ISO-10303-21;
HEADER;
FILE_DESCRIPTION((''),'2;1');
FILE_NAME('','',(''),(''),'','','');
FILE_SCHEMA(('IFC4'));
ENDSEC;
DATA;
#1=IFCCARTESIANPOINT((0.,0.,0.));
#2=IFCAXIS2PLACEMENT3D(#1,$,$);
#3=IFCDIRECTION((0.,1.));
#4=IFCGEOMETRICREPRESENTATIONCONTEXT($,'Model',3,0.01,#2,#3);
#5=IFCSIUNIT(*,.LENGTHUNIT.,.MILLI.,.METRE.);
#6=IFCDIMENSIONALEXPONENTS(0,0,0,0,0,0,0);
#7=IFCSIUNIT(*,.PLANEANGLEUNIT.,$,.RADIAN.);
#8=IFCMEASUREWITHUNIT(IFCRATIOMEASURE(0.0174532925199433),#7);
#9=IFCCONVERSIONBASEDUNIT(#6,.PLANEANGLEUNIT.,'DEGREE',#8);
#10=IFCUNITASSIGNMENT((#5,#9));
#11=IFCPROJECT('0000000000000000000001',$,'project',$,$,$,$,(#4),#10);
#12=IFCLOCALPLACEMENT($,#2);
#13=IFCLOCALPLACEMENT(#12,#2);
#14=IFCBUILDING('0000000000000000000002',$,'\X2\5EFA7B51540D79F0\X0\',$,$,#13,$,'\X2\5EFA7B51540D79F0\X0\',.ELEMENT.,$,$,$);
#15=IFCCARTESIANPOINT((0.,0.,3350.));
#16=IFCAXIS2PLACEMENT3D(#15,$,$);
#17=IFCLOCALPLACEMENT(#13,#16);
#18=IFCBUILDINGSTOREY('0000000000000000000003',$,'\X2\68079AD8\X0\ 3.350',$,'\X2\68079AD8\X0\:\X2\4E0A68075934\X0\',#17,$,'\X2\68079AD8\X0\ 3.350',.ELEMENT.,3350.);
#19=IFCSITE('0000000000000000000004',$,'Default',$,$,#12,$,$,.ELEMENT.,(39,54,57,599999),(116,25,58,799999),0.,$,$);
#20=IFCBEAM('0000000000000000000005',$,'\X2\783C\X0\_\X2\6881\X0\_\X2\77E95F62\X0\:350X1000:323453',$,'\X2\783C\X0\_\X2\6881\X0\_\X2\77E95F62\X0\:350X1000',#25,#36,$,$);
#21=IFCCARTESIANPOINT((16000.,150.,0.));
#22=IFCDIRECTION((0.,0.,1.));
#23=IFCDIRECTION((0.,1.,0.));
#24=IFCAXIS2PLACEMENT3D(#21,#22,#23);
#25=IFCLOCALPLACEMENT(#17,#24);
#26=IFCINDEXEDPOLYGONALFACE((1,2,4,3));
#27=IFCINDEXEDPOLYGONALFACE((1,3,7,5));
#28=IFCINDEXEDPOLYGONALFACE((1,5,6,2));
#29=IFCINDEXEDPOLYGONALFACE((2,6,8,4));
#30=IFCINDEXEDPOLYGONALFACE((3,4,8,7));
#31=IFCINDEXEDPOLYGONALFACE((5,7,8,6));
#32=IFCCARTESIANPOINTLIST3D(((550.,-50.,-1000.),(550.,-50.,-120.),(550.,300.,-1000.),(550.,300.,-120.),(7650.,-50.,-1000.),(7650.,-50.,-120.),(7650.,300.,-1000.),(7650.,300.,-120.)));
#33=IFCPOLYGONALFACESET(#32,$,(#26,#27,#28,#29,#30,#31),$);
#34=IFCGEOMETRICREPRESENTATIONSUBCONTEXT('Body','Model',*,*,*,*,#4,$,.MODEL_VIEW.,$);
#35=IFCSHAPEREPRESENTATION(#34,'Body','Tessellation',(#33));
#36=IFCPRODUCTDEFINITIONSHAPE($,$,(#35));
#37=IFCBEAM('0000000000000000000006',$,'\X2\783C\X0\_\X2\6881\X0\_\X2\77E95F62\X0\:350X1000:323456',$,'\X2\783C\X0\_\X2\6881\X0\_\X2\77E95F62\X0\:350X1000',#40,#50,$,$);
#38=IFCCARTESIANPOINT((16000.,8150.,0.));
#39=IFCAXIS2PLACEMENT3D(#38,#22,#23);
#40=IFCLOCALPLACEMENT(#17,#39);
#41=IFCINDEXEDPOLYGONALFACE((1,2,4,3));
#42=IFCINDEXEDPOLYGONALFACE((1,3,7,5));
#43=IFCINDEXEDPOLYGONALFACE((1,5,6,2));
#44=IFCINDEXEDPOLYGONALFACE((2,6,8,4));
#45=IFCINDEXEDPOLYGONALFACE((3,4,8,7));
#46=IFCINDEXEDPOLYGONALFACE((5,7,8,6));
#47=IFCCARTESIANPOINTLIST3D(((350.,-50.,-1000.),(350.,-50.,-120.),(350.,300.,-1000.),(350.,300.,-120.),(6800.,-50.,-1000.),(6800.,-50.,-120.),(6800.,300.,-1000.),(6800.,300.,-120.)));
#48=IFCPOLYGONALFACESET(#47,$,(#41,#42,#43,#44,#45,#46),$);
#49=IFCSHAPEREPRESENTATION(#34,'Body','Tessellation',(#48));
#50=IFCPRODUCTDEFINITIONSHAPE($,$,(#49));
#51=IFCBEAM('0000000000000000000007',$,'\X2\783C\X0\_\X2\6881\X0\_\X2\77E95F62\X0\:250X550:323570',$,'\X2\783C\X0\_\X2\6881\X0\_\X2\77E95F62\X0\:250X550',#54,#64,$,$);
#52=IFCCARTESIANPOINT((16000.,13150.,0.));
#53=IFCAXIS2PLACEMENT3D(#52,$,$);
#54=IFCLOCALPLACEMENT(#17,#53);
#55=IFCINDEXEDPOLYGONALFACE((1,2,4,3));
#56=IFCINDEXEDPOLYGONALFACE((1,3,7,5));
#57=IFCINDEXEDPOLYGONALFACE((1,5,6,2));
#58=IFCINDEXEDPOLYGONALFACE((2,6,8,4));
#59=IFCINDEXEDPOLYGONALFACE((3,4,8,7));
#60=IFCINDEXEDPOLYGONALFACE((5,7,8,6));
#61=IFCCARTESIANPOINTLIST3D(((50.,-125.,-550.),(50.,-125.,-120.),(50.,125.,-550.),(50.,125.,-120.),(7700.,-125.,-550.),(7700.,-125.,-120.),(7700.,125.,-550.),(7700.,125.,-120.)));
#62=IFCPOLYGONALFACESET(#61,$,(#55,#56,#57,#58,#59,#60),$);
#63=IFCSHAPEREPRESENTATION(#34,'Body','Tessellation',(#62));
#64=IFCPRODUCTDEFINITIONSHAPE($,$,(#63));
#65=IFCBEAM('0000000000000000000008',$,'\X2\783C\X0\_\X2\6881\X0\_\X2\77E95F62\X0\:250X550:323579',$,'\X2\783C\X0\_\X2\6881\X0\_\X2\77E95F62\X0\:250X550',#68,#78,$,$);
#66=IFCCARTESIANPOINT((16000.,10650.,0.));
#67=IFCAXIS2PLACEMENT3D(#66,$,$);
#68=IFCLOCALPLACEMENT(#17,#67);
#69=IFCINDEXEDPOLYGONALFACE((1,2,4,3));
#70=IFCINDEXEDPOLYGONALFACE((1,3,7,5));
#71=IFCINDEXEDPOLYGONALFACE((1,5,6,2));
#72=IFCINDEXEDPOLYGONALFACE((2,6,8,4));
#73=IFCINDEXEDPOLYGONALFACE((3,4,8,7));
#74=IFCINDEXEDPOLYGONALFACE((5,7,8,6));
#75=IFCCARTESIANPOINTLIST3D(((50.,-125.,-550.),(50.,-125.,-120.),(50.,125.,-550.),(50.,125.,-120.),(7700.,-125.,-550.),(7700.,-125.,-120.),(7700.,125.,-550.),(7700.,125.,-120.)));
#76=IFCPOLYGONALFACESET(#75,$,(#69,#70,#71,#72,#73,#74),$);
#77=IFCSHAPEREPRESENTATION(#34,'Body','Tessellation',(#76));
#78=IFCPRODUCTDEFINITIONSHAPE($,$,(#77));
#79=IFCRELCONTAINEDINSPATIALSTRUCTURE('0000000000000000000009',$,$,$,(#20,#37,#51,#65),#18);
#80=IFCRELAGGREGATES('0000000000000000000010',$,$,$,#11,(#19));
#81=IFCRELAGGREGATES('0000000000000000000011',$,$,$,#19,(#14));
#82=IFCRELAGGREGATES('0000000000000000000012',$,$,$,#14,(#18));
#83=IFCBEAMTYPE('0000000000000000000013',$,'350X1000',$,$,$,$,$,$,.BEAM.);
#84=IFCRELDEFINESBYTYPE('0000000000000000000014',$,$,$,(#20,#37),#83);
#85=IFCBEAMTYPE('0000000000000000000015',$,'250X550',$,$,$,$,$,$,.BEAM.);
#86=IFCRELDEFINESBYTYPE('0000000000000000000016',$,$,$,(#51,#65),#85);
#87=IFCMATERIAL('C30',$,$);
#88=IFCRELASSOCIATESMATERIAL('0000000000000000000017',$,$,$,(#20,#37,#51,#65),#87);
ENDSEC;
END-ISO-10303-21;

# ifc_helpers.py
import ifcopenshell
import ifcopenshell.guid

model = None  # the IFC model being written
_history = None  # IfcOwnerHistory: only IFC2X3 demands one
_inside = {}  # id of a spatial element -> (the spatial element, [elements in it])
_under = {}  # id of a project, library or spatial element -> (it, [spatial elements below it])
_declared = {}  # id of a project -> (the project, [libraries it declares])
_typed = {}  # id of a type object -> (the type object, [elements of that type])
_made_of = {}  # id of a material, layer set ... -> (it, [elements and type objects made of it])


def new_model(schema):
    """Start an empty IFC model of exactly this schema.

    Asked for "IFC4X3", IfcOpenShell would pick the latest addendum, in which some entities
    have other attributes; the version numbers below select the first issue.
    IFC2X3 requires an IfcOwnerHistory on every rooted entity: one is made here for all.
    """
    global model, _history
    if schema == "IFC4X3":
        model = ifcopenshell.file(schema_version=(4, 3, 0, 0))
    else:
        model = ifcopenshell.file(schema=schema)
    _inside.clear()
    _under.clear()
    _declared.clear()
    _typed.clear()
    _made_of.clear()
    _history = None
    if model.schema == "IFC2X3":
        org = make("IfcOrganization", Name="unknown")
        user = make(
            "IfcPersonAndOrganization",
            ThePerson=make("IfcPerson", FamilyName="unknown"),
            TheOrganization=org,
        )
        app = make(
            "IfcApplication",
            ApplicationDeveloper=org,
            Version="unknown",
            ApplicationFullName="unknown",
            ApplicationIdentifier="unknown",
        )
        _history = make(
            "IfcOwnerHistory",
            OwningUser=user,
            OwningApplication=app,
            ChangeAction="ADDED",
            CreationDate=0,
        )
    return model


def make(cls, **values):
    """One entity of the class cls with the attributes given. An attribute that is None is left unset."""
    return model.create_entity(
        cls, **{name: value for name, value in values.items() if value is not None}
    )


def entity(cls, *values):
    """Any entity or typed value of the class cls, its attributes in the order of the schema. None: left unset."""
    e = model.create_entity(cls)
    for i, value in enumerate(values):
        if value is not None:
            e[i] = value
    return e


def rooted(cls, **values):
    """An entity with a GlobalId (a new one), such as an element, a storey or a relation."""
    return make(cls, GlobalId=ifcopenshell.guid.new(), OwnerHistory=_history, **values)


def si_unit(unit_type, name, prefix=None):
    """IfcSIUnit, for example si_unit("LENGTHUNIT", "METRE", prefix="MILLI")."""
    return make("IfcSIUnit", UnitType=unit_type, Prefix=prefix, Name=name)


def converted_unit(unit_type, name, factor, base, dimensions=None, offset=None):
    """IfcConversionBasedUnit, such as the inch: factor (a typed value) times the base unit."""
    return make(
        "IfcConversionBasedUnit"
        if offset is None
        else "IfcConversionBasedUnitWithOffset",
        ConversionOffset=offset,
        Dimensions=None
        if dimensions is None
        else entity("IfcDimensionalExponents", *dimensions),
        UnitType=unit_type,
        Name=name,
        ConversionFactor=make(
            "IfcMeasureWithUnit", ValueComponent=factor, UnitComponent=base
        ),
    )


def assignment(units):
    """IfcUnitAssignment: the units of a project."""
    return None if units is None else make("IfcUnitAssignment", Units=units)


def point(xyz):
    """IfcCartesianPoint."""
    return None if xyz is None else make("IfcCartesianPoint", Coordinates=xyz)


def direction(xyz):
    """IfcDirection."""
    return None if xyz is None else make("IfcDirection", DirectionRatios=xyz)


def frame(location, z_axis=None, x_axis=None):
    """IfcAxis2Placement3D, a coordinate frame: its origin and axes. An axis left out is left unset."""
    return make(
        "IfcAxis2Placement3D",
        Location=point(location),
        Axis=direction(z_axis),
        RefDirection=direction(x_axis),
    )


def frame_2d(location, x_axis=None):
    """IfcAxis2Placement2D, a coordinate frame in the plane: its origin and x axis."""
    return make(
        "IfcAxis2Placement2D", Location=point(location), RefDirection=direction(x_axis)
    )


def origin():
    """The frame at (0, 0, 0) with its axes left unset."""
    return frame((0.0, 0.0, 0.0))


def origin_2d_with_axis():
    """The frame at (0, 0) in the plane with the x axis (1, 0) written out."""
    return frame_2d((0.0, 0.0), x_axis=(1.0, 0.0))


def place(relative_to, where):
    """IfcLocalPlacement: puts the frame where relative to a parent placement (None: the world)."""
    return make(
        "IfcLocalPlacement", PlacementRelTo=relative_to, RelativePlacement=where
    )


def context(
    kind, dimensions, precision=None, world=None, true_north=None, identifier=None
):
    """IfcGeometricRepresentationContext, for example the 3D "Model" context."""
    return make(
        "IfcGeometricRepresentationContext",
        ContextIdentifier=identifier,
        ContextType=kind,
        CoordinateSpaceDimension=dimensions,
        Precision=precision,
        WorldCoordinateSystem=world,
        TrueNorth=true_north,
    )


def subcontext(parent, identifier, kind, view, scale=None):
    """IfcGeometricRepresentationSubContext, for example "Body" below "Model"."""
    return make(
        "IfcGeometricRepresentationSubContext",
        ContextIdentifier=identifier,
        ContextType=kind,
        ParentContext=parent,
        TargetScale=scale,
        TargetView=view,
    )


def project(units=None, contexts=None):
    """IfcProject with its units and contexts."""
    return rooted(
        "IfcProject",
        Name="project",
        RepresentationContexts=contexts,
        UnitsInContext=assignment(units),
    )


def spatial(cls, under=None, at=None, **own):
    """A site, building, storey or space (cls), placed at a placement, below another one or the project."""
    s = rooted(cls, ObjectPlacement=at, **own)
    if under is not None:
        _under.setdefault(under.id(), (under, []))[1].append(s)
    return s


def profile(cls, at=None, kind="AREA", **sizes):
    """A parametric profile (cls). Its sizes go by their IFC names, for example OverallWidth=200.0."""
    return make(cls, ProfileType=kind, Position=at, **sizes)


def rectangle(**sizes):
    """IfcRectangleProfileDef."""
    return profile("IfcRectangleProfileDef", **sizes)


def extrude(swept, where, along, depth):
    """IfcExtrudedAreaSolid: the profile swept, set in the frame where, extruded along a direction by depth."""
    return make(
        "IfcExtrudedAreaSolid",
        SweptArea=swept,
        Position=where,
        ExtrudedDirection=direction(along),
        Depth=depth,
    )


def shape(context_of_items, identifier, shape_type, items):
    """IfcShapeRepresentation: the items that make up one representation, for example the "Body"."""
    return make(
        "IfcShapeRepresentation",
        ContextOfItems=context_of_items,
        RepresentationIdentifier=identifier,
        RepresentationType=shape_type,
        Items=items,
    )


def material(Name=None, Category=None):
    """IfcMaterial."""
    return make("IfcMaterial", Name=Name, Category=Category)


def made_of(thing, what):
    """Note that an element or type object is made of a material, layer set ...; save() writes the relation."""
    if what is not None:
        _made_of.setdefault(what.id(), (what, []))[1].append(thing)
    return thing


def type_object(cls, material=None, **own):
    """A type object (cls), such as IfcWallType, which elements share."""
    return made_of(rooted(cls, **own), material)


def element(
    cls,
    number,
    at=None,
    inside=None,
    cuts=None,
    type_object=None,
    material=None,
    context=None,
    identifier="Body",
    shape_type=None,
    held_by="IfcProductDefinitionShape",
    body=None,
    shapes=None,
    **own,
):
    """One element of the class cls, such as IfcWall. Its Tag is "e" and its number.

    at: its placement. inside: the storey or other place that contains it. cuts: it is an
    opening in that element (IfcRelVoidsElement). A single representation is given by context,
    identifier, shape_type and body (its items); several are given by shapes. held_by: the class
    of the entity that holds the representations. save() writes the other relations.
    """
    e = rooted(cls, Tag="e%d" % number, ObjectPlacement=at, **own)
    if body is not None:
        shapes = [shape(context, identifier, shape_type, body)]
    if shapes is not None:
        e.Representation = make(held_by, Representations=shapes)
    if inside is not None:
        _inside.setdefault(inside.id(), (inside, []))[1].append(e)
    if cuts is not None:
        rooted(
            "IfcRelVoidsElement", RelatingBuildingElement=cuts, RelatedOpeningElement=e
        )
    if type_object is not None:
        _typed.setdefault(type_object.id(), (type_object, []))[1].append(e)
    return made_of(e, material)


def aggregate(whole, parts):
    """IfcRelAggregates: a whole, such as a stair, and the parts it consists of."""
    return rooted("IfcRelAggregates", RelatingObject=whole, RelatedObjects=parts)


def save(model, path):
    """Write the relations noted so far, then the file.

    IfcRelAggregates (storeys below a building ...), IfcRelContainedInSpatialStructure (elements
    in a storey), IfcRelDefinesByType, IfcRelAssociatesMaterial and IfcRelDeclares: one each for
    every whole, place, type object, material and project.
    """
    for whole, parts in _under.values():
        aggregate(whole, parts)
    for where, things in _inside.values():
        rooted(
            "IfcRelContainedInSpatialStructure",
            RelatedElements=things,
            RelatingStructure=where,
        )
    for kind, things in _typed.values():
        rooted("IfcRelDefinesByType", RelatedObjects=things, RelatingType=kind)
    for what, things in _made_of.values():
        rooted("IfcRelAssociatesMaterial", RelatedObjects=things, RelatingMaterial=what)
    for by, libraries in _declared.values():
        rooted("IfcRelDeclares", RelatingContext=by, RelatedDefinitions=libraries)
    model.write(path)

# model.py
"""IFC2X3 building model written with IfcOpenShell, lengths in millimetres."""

from ifc_helpers import new_model, entity, si_unit, converted_unit, direction, frame, frame_2d, origin, origin_2d_with_axis, place, context, subcontext, project, spatial, rectangle, extrude, material, type_object, element, save


model = new_model("IFC2X3")

# Units and contexts
model_context = context("Model", 3, precision=0.01, world=origin(), true_north=direction((0.0, 1.0)))
body_context = subcontext(model_context, "Body", "Model", "MODEL_VIEW")
ifc_project = project(units=[si_unit("LENGTHUNIT", "METRE", prefix="MILLI"), converted_unit("PLANEANGLEUNIT", "DEGREE", entity("IfcRatioMeasure", 0.0174532925199433), si_unit("PLANEANGLEUNIT", "RADIAN"), dimensions=[0, 0, 0, 0, 0, 0, 0])], contexts=[model_context])

# Site, building, storey
site_placement = place(None, origin())
site = spatial("IfcSite", under=ifc_project, at=site_placement, Name="Default", CompositionType="ELEMENT", RefLatitude=(39, 54, 57, 599999), RefLongitude=(116, 25, 58, 799999), RefElevation=0.0)
building_placement = place(site_placement, origin())
building = spatial("IfcBuilding", under=site, at=building_placement, Name="建筑名称", LongName="建筑名称", CompositionType="ELEMENT")
storey_placement = place(building_placement, frame((0.0, 0.0, 3350.0)))
storey = spatial("IfcBuildingStorey", under=building, at=storey_placement, Name="标高 3.350", ObjectType="标高:上标头", LongName="标高 3.350", CompositionType="ELEMENT", Elevation=3350.0)

# Beams
ifc_material_1 = material(Name="C30")
beam_type_1 = type_object("IfcBeamType", Name="350X1000", PredefinedType="BEAM")
beam_1_placement = place(storey_placement, frame((16000.0, 150.0, 0.0), z_axis=(0.0, 0.0, 1.0), x_axis=(0.0, 1.0, 0.0)))
element("IfcBeam", 1, at=beam_1_placement, inside=storey, type_object=beam_type_1, material=ifc_material_1, Name="砼_梁_矩形:350X1000:323453", ObjectType="砼_梁_矩形:350X1000", context=body_context, shape_type="SweptSolid", body=[
    extrude(rectangle(XDim=880.0, YDim=350.0, at=frame_2d((0.0, 0.0), x_axis=(1.0, 0.0))), frame((550.0, 125.0, -560.0), z_axis=(1.0, 0.0, 0.0), x_axis=(0.0, 0.0, -1.0)), (0.0, 0.0, 1.0), 7100.0),
])
beam_2_placement = place(storey_placement, frame((16000.0, 8150.0, 0.0), z_axis=(0.0, 0.0, 1.0), x_axis=(0.0, 1.0, 0.0)))
element("IfcBeam", 2, at=beam_2_placement, inside=storey, type_object=beam_type_1, material=ifc_material_1, Name="砼_梁_矩形:350X1000:323456", ObjectType="砼_梁_矩形:350X1000", context=body_context, shape_type="SweptSolid", body=[
    extrude(rectangle(XDim=880.0, YDim=350.0, at=frame_2d((0.0, 0.0), x_axis=(1.0, 0.0))), frame((350.0, 125.0, -560.0), z_axis=(1.0, 0.0, 0.0), x_axis=(0.0, 0.0, -1.0)), (0.0, 0.0, 1.0), 6450.0),
])
beam_type_2 = type_object("IfcBeamType", Name="250X550", PredefinedType="BEAM")
beam_3_placement = place(storey_placement, frame((16000.0, 13150.0, 0.0)))
element("IfcBeam", 3, at=beam_3_placement, inside=storey, type_object=beam_type_2, material=ifc_material_1, Name="砼_梁_矩形:250X550:323570", ObjectType="砼_梁_矩形:250X550", context=body_context, shape_type="SweptSolid", body=[
    extrude(rectangle(XDim=430.0, YDim=250.0, at=frame_2d((0.0, 0.0), x_axis=(1.0, 0.0))), frame((50.0, 0.0, -335.0), z_axis=(1.0, 0.0, 0.0), x_axis=(0.0, 0.0, -1.0)), (0.0, 0.0, 1.0), 7650.0),
])
beam_4_placement = place(storey_placement, frame((16000.0, 10650.0, 0.0)))
element("IfcBeam", 4, at=beam_4_placement, inside=storey, type_object=beam_type_2, material=ifc_material_1, Name="砼_梁_矩形:250X550:323579", ObjectType="砼_梁_矩形:250X550", context=body_context, shape_type="SweptSolid", body=[
    extrude(rectangle(XDim=430.0, YDim=250.0, at=origin_2d_with_axis()), frame((50.0, 0.0, -335.0), z_axis=(1.0, 0.0, 0.0), x_axis=(0.0, 0.0, -1.0)), (0.0, 0.0, 1.0), 7650.0),
])

save(model, "model.ifc")
